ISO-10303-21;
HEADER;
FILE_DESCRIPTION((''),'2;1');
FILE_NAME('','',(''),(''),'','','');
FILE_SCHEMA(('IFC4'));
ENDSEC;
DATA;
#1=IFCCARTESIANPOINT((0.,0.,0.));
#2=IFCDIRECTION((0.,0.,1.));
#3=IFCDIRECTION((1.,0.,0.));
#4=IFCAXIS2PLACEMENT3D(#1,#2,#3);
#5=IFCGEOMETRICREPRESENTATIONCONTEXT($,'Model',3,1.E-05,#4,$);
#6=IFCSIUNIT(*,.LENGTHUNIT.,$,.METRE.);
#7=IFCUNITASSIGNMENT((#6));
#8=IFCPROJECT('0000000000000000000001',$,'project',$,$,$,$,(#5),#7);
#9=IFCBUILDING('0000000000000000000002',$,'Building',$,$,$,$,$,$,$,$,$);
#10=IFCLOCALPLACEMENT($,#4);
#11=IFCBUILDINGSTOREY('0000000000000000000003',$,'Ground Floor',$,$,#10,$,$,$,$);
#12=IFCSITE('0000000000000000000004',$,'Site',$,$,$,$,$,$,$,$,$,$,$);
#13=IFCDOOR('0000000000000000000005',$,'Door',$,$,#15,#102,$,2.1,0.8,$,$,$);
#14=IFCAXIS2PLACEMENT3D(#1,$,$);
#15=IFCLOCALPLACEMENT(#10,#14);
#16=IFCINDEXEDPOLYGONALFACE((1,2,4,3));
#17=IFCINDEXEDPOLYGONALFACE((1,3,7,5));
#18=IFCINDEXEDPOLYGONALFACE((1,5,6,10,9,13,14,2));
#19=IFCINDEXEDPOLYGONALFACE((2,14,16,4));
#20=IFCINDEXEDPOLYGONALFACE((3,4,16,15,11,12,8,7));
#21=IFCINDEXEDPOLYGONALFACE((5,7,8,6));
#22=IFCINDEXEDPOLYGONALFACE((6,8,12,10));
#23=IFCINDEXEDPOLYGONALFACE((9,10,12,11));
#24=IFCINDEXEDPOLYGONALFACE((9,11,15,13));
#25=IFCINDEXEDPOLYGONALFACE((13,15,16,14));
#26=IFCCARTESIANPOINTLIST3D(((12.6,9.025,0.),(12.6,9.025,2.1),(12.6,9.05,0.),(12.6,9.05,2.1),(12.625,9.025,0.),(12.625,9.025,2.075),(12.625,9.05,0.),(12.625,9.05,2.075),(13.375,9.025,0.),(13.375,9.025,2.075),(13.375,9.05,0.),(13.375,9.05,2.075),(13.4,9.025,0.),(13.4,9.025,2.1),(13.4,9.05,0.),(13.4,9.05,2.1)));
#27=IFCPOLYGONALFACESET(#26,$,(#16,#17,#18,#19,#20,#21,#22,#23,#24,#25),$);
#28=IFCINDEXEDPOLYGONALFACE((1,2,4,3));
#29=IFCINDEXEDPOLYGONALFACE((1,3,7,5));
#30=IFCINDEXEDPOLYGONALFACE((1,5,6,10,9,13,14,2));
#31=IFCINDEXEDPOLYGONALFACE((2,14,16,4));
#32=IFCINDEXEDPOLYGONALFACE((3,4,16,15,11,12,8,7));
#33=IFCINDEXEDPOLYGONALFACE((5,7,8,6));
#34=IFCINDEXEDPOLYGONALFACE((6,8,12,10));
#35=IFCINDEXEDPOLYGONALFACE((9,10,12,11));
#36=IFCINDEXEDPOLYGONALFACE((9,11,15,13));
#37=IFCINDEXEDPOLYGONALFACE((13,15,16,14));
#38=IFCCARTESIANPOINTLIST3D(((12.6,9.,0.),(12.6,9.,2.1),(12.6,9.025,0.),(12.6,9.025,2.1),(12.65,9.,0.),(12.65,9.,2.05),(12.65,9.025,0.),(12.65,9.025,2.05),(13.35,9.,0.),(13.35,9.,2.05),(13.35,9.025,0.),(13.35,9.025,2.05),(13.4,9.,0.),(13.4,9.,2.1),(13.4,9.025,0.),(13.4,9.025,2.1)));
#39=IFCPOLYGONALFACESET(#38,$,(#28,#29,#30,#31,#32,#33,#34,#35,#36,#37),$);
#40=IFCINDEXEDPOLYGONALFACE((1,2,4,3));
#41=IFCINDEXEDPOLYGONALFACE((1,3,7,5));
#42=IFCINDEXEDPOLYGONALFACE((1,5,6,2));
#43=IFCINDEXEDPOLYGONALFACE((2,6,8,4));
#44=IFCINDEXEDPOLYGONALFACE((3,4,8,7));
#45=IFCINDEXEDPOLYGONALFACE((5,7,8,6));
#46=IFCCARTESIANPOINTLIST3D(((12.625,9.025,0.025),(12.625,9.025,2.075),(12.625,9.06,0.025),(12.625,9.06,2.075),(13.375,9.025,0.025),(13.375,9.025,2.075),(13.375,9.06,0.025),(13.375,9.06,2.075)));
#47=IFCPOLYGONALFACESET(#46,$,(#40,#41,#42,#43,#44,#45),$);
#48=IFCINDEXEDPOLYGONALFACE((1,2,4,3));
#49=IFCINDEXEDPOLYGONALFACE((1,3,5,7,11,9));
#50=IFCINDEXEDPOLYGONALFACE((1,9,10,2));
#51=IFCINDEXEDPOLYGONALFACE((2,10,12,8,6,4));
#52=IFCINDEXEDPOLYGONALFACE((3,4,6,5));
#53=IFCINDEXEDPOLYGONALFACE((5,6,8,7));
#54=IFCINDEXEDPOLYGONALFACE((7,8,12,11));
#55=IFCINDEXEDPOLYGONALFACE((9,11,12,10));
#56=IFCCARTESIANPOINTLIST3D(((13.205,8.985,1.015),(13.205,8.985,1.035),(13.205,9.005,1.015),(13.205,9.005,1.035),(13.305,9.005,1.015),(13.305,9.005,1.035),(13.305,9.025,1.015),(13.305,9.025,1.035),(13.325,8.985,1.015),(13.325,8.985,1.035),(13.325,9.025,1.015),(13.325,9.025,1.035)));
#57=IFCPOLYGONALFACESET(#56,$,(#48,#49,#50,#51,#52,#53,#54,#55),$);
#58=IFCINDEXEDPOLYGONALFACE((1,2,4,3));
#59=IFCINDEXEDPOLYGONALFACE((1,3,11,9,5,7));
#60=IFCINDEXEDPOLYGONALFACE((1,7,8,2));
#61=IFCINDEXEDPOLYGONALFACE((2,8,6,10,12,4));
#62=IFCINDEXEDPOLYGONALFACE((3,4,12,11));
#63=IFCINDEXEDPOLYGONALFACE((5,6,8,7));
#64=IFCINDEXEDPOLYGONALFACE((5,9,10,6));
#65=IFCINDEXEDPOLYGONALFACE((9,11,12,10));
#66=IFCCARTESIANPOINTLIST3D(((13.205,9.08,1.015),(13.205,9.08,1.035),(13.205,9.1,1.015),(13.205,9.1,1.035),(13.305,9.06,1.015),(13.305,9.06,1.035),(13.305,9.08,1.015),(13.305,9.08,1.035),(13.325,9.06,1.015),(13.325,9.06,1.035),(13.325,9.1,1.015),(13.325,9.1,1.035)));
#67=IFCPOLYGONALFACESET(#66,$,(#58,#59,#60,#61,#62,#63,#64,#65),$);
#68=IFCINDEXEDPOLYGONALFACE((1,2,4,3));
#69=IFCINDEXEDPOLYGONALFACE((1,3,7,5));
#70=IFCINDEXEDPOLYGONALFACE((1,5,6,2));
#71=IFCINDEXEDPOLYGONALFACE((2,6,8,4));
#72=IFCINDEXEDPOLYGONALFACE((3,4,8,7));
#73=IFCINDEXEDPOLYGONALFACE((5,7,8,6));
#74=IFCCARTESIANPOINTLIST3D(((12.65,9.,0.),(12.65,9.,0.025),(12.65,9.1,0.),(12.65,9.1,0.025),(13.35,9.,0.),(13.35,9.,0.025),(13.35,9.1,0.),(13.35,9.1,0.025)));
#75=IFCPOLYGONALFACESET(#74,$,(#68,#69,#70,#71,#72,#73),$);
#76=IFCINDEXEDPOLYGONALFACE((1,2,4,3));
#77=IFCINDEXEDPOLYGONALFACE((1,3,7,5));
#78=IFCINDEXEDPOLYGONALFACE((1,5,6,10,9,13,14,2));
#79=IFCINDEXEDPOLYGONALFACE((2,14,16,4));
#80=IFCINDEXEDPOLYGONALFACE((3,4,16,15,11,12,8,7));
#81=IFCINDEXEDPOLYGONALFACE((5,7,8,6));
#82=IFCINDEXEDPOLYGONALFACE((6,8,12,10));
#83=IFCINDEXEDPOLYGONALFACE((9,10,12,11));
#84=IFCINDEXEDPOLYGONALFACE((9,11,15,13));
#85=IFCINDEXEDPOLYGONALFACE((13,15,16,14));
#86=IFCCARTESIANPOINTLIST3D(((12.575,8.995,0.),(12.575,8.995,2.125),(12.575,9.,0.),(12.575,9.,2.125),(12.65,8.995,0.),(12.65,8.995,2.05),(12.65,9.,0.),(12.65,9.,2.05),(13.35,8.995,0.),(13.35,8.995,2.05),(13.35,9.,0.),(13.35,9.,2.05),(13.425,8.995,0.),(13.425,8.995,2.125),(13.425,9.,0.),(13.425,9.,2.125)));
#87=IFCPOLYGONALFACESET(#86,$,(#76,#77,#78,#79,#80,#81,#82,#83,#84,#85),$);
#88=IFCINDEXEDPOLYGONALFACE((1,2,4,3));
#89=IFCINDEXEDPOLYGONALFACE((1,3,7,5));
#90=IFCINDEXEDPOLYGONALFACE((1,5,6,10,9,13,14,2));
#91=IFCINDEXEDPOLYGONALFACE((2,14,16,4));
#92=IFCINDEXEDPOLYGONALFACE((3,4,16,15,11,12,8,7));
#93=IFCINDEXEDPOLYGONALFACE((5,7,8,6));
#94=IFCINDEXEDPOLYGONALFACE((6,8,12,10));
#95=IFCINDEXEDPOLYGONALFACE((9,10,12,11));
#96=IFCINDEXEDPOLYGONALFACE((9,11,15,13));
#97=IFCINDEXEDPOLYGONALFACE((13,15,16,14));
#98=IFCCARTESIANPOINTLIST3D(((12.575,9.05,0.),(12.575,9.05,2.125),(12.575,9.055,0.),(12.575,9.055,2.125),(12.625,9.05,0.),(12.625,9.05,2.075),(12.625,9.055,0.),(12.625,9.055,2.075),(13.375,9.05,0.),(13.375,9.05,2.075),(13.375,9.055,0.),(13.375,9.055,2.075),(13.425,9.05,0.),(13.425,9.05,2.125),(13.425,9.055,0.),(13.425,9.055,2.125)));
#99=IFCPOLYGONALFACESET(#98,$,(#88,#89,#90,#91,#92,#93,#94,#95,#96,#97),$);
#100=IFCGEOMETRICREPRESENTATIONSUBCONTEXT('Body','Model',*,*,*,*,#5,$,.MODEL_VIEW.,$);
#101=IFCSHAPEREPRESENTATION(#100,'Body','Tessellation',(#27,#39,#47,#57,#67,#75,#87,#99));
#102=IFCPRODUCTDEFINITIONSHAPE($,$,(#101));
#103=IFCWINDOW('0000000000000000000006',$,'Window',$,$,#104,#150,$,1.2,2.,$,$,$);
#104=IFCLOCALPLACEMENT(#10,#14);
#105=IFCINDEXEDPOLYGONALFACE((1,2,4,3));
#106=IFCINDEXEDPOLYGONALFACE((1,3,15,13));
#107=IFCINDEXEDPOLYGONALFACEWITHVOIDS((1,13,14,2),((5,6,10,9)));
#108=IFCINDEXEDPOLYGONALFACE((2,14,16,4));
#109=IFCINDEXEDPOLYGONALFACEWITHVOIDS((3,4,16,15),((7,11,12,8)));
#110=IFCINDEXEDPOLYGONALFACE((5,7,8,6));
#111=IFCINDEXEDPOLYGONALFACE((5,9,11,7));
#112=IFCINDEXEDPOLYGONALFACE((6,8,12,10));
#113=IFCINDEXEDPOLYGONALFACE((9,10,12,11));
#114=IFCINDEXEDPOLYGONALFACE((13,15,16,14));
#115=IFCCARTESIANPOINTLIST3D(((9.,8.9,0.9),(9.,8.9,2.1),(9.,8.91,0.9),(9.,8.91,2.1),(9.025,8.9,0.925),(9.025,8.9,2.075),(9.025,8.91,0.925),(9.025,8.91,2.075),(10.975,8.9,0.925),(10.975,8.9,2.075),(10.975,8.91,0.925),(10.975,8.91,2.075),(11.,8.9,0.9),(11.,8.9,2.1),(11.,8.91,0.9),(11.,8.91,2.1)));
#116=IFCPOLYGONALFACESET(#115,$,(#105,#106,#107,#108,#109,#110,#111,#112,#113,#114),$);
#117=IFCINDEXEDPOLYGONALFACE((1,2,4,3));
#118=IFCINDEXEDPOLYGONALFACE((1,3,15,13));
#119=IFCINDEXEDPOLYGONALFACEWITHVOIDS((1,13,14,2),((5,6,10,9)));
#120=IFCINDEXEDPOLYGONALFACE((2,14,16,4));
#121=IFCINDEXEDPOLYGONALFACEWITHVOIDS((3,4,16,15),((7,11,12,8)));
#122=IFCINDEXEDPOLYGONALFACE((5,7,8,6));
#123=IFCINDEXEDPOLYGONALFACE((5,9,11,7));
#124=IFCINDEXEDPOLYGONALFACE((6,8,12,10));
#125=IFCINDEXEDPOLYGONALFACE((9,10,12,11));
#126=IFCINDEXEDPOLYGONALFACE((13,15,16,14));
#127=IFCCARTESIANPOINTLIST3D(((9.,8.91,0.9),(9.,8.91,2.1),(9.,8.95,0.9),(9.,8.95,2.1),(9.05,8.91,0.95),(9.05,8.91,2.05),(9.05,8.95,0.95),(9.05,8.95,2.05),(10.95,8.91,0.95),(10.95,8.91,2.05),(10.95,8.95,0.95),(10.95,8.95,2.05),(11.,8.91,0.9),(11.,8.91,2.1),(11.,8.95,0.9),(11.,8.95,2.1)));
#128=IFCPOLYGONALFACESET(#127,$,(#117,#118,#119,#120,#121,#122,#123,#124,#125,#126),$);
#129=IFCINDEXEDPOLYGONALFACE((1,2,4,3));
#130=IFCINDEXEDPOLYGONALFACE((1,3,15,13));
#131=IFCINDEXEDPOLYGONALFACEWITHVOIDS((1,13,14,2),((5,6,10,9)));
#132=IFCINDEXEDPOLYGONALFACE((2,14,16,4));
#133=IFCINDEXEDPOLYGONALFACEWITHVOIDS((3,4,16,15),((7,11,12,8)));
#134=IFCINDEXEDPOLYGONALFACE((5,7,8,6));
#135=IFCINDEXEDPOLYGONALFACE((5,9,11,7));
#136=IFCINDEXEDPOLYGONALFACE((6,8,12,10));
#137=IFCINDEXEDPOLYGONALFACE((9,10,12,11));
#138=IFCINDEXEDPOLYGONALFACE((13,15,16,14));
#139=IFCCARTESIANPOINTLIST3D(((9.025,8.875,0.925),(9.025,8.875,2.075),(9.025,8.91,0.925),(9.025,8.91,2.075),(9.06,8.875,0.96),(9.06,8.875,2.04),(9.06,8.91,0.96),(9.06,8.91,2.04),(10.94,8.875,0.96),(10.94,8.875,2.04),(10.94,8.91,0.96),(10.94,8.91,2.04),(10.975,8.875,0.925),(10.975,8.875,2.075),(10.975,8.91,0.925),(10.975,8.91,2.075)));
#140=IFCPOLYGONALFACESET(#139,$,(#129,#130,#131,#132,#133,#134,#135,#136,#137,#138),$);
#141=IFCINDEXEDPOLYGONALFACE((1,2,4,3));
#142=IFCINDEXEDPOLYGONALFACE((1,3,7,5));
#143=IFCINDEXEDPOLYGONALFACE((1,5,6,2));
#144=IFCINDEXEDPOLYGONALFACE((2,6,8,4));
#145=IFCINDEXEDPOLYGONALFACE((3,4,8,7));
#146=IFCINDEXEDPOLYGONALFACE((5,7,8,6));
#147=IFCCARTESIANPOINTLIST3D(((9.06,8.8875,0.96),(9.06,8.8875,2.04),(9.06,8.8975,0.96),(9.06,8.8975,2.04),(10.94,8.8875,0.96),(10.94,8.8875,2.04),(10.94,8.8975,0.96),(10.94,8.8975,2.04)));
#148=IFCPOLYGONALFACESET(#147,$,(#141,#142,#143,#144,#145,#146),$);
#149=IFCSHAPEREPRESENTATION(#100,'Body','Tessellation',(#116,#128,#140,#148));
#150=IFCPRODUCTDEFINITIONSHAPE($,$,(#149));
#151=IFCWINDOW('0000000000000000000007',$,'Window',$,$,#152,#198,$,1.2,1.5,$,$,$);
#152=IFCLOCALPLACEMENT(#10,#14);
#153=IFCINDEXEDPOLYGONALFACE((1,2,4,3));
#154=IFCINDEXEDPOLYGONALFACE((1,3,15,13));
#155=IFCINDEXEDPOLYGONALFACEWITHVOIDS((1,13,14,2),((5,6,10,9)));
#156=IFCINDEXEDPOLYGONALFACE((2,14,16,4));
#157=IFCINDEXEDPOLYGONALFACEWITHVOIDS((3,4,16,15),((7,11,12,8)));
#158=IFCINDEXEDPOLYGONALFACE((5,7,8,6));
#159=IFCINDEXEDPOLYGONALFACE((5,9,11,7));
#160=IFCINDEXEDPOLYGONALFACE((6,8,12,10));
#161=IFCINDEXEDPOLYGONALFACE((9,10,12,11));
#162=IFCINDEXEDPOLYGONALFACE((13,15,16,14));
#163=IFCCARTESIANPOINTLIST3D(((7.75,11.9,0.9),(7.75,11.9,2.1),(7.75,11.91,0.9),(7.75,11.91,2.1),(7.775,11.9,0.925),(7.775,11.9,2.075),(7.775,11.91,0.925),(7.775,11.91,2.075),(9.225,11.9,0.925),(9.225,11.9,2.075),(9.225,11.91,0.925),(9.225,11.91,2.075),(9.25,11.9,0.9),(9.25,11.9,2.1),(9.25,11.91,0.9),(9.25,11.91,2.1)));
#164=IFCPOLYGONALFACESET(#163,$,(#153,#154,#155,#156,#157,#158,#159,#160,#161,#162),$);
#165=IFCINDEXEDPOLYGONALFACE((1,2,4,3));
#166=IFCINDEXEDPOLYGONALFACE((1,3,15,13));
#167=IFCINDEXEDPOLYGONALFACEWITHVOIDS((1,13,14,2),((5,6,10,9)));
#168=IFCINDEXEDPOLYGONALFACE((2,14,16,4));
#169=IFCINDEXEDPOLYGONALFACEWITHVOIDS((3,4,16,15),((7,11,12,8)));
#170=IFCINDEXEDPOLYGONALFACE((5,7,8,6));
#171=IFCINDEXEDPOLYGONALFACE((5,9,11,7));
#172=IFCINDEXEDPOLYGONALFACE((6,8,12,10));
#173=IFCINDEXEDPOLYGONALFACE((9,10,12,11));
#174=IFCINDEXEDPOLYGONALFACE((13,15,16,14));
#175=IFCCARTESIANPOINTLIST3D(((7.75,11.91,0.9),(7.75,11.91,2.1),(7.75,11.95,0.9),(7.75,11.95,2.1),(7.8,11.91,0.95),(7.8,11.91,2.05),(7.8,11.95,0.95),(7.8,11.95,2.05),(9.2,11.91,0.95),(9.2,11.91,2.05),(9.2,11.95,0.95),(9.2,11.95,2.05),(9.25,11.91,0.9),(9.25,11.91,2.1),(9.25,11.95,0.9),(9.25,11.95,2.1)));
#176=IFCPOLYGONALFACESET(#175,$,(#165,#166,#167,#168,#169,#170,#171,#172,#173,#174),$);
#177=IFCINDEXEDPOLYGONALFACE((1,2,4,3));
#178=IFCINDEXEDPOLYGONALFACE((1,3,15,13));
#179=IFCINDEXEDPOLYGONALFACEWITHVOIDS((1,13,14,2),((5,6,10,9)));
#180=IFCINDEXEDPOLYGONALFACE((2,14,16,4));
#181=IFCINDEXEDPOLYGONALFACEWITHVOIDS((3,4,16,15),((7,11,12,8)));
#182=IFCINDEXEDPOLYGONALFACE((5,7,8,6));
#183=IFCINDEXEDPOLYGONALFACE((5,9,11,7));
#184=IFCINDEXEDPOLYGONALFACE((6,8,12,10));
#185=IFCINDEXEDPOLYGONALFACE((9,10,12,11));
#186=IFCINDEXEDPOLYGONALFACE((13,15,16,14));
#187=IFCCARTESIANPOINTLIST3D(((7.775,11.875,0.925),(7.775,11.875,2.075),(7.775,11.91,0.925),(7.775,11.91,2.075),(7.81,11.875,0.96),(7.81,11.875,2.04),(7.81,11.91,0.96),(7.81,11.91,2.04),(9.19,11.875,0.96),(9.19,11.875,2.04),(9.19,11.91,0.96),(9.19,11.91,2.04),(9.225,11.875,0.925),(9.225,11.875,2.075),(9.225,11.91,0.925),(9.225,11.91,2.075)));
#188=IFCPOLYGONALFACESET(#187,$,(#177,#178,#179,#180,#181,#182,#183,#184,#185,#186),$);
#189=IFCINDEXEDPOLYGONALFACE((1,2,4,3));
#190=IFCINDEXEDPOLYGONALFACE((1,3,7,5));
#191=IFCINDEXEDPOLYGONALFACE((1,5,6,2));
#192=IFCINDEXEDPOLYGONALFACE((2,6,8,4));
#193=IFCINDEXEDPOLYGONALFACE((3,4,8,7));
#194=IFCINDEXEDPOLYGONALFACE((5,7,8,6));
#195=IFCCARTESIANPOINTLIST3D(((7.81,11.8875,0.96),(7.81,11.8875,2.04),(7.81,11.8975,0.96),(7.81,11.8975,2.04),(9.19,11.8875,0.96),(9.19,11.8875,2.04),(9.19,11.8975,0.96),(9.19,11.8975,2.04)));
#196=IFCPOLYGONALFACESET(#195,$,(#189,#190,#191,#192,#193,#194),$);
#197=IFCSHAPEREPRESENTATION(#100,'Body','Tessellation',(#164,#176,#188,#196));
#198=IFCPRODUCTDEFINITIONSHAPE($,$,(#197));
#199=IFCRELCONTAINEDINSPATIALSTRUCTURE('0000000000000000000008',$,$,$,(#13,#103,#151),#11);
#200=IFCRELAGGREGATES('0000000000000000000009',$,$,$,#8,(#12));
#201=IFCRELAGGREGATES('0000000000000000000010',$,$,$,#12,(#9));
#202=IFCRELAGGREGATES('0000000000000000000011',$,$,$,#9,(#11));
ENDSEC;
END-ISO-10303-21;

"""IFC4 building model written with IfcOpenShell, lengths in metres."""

from ifc_helpers import new_model, si_unit, frame, origin_with_axes, place, context, subcontext, project, spatial, line, indexed_curve, outline, extrude, element, save


model = new_model("IFC4")

# Units and contexts
model_context = context("Model", 3, precision=1e-05, world=origin_with_axes())
body_context = subcontext(model_context, "Body", "Model", "MODEL_VIEW")
ifc_project = project(units=[si_unit("LENGTHUNIT", "METRE")], contexts=[model_context])

# Site, building, storey
site = spatial("IfcSite", under=ifc_project, Name="Site")
building = spatial("IfcBuilding", under=site, Name="Building")
storey_placement = place(None, origin_with_axes())
storey = spatial("IfcBuildingStorey", under=building, at=storey_placement, Name="Ground Floor")

# Door
door_1_placement = place(storey_placement, frame((12.6, 9.0, 0.0), z_axis=(0.0, 0.0, 1.0), x_axis=(1.0, 0.0, 0.0)))
element("IfcDoor", 1, at=door_1_placement, inside=storey, Name="Door", OverallHeight=2.1, OverallWidth=0.8, context=body_context, shape_type="SweptSolid", body=[
    extrude(outline(indexed_curve([(0.0, 0.0), (0.0, 2.1), (0.8, 2.1), (0.8, 0.0), (0.775, 0.0), (0.775, 2.075), (0.025, 2.075), (0.025, 0.0)], segments=[line(1, 2, 3, 4, 5, 6, 7, 8, 1)])), frame((0.0, 0.025, 0.0), z_axis=(0.0, -1.0, 0.0), x_axis=(1.0, 0.0, 0.0)), (0.0, 0.0, -1.0), 0.025),
    extrude(outline(indexed_curve([(0.0, 0.0), (0.0, 2.1), (0.8, 2.1), (0.8, 0.0), (0.75, 0.0), (0.75, 2.05), (0.05, 2.05), (0.05, 0.0)], segments=[line(1, 2, 3, 4, 5, 6, 7, 8, 1)])), frame((0.0, 0.0, 0.0), z_axis=(0.0, -1.0, 0.0), x_axis=(1.0, 0.0, 0.0)), (0.0, 0.0, -1.0), 0.025),
    extrude(outline(indexed_curve([(0.0, 0.0), (0.75, 0.0), (0.75, 0.035), (0.0, 0.035)], segments=[line(1, 2, 3, 4, 1)])), frame((0.025, 0.025, 0.025), z_axis=(0.0, 0.0, 1.0), x_axis=(1.0, 0.0, 0.0)), (0.0, 0.0, 1.0), 2.05),
    extrude(outline(indexed_curve([(0.0, 0.0), (0.0, -0.04), (-0.12, -0.04), (-0.12, -0.02), (-0.02, -0.02), (-0.02, 0.0)], segments=[line(1, 2, 3, 4, 5, 6, 1)])), frame((0.725, 0.025, 1.015), z_axis=(0.0, 0.0, 1.0), x_axis=(1.0, 0.0, 0.0)), (0.0, 0.0, 1.0), 0.02),
    extrude(outline(indexed_curve([(0.0, 0.0), (0.0, 0.04), (-0.12, 0.04), (-0.12, 0.02), (-0.02, 0.02), (-0.02, 0.0)], segments=[line(1, 2, 3, 4, 5, 6, 1)])), frame((0.725, 0.06, 1.015), z_axis=(0.0, 0.0, 1.0), x_axis=(1.0, 0.0, 0.0)), (0.0, 0.0, 1.0), 0.02),
    extrude(outline(indexed_curve([(0.0, 0.0), (0.7, 0.0), (0.7, 0.1), (0.0, 0.1)], segments=[line(1, 2, 3, 4, 1)])), frame((0.05, 0.0, 0.0), z_axis=(0.0, 0.0, 1.0), x_axis=(1.0, 0.0, 0.0)), (0.0, 0.0, 1.0), 0.025),
    extrude(outline(indexed_curve([(0.0, 0.0), (0.0, 2.125), (0.85, 2.125), (0.85, 0.0), (0.775, 0.0), (0.775, 2.05), (0.075, 2.05), (0.075, 0.0)], segments=[line(1, 2, 3, 4, 5, 6, 7, 8, 1)])), frame((-0.025, -0.005, 0.0), z_axis=(0.0, -1.0, 0.0), x_axis=(1.0, 0.0, 0.0)), (0.0, 0.0, -1.0), 0.005),
    extrude(outline(indexed_curve([(0.0, 0.0), (0.0, 2.125), (0.85, 2.125), (0.85, 0.0), (0.8, 0.0), (0.8, 2.075), (0.05, 2.075), (0.05, 0.0)], segments=[line(1, 2, 3, 4, 5, 6, 7, 8, 1)])), frame((-0.025, 0.05, 0.0), z_axis=(0.0, -1.0, 0.0), x_axis=(1.0, 0.0, 0.0)), (0.0, 0.0, -1.0), 0.005),
])

# Windows
window_1_placement = place(storey_placement, frame((11.0, 9.0, 0.9), z_axis=(0.0, 0.0, 1.0), x_axis=(-1.0, 0.0, 0.0)))
element("IfcWindow", 2, at=window_1_placement, inside=storey, Name="Window", OverallHeight=1.2, OverallWidth=2.0, context=body_context, shape_type="SweptSolid", body=[
    extrude(outline(indexed_curve([(0.0, 0.0), (2.0, 0.0), (2.0, 1.2), (0.0, 1.2)], segments=[line(1, 2, 3, 4, 1)]), holes=[indexed_curve([(0.025, 0.025), (1.975, 0.025), (1.975, 1.175), (0.025, 1.175)], segments=[line(1, 2, 3, 4, 1)])]), frame((0.0, 0.09, 0.0), z_axis=(0.0, -1.0, 0.0), x_axis=(1.0, 0.0, 0.0)), (0.0, 0.0, -1.0), 0.01),
    extrude(outline(indexed_curve([(0.0, 0.0), (2.0, 0.0), (2.0, 1.2), (0.0, 1.2)], segments=[line(1, 2, 3, 4, 1)]), holes=[indexed_curve([(0.05, 0.05), (1.95, 0.05), (1.95, 1.15), (0.05, 1.15)], segments=[line(1, 2, 3, 4, 1)])]), frame((0.0, 0.05, 0.0), z_axis=(0.0, -1.0, 0.0), x_axis=(1.0, 0.0, 0.0)), (0.0, 0.0, -1.0), 0.04),
    extrude(outline(indexed_curve([(0.0, 0.0), (1.95, 0.0), (1.95, 1.15), (0.0, 1.15)], segments=[line(1, 2, 3, 4, 1)]), holes=[indexed_curve([(0.035, 0.035), (1.915, 0.035), (1.915, 1.115), (0.035, 1.115)], segments=[line(1, 2, 3, 4, 1)])]), frame((0.025, 0.09, 0.025), z_axis=(0.0, -1.0, 0.0), x_axis=(1.0, 0.0, 0.0)), (0.0, 0.0, -1.0), 0.035),
    extrude(outline(indexed_curve([(0.035, 0.035), (1.915, 0.035), (1.915, 1.115), (0.035, 1.115)], segments=[line(1, 2, 3, 4, 1)])), frame((0.025, 0.1025, 0.025), z_axis=(0.0, -1.0, 0.0), x_axis=(1.0, 0.0, 0.0)), (0.0, 0.0, -1.0), 0.01),
])
window_2_placement = place(storey_placement, frame((9.25, 12.0, 0.9), z_axis=(0.0, 0.0, 1.0), x_axis=(-1.0, 0.0, 0.0)))
element("IfcWindow", 3, at=window_2_placement, inside=storey, Name="Window", OverallHeight=1.2, OverallWidth=1.5, context=body_context, shape_type="SweptSolid", body=[
    extrude(outline(indexed_curve([(0.0, 0.0), (1.5, 0.0), (1.5, 1.2), (0.0, 1.2)], segments=[line(1, 2, 3, 4, 1)]), holes=[indexed_curve([(0.025, 0.025), (1.475, 0.025), (1.475, 1.175), (0.025, 1.175)], segments=[line(1, 2, 3, 4, 1)])]), frame((0.0, 0.09, 0.0), z_axis=(0.0, -1.0, 0.0), x_axis=(1.0, 0.0, 0.0)), (0.0, 0.0, -1.0), 0.01),
    extrude(outline(indexed_curve([(0.0, 0.0), (1.5, 0.0), (1.5, 1.2), (0.0, 1.2)], segments=[line(1, 2, 3, 4, 1)]), holes=[indexed_curve([(0.05, 0.05), (1.45, 0.05), (1.45, 1.15), (0.05, 1.15)], segments=[line(1, 2, 3, 4, 1)])]), frame((0.0, 0.05, 0.0), z_axis=(0.0, -1.0, 0.0), x_axis=(1.0, 0.0, 0.0)), (0.0, 0.0, -1.0), 0.04),
    extrude(outline(indexed_curve([(0.0, 0.0), (1.45, 0.0), (1.45, 1.15), (0.0, 1.15)], segments=[line(1, 2, 3, 4, 1)]), holes=[indexed_curve([(0.035, 0.035), (1.415, 0.035), (1.415, 1.115), (0.035, 1.115)], segments=[line(1, 2, 3, 4, 1)])]), frame((0.025, 0.09, 0.025), z_axis=(0.0, -1.0, 0.0), x_axis=(1.0, 0.0, 0.0)), (0.0, 0.0, -1.0), 0.035),
    extrude(outline(indexed_curve([(0.035, 0.035), (1.415, 0.035), (1.415, 1.115), (0.035, 1.115)], segments=[line(1, 2, 3, 4, 1)])), frame((0.025, 0.1025, 0.025), z_axis=(0.0, -1.0, 0.0), x_axis=(1.0, 0.0, 0.0)), (0.0, 0.0, -1.0), 0.01),
])

save(model, "model.ifc")
